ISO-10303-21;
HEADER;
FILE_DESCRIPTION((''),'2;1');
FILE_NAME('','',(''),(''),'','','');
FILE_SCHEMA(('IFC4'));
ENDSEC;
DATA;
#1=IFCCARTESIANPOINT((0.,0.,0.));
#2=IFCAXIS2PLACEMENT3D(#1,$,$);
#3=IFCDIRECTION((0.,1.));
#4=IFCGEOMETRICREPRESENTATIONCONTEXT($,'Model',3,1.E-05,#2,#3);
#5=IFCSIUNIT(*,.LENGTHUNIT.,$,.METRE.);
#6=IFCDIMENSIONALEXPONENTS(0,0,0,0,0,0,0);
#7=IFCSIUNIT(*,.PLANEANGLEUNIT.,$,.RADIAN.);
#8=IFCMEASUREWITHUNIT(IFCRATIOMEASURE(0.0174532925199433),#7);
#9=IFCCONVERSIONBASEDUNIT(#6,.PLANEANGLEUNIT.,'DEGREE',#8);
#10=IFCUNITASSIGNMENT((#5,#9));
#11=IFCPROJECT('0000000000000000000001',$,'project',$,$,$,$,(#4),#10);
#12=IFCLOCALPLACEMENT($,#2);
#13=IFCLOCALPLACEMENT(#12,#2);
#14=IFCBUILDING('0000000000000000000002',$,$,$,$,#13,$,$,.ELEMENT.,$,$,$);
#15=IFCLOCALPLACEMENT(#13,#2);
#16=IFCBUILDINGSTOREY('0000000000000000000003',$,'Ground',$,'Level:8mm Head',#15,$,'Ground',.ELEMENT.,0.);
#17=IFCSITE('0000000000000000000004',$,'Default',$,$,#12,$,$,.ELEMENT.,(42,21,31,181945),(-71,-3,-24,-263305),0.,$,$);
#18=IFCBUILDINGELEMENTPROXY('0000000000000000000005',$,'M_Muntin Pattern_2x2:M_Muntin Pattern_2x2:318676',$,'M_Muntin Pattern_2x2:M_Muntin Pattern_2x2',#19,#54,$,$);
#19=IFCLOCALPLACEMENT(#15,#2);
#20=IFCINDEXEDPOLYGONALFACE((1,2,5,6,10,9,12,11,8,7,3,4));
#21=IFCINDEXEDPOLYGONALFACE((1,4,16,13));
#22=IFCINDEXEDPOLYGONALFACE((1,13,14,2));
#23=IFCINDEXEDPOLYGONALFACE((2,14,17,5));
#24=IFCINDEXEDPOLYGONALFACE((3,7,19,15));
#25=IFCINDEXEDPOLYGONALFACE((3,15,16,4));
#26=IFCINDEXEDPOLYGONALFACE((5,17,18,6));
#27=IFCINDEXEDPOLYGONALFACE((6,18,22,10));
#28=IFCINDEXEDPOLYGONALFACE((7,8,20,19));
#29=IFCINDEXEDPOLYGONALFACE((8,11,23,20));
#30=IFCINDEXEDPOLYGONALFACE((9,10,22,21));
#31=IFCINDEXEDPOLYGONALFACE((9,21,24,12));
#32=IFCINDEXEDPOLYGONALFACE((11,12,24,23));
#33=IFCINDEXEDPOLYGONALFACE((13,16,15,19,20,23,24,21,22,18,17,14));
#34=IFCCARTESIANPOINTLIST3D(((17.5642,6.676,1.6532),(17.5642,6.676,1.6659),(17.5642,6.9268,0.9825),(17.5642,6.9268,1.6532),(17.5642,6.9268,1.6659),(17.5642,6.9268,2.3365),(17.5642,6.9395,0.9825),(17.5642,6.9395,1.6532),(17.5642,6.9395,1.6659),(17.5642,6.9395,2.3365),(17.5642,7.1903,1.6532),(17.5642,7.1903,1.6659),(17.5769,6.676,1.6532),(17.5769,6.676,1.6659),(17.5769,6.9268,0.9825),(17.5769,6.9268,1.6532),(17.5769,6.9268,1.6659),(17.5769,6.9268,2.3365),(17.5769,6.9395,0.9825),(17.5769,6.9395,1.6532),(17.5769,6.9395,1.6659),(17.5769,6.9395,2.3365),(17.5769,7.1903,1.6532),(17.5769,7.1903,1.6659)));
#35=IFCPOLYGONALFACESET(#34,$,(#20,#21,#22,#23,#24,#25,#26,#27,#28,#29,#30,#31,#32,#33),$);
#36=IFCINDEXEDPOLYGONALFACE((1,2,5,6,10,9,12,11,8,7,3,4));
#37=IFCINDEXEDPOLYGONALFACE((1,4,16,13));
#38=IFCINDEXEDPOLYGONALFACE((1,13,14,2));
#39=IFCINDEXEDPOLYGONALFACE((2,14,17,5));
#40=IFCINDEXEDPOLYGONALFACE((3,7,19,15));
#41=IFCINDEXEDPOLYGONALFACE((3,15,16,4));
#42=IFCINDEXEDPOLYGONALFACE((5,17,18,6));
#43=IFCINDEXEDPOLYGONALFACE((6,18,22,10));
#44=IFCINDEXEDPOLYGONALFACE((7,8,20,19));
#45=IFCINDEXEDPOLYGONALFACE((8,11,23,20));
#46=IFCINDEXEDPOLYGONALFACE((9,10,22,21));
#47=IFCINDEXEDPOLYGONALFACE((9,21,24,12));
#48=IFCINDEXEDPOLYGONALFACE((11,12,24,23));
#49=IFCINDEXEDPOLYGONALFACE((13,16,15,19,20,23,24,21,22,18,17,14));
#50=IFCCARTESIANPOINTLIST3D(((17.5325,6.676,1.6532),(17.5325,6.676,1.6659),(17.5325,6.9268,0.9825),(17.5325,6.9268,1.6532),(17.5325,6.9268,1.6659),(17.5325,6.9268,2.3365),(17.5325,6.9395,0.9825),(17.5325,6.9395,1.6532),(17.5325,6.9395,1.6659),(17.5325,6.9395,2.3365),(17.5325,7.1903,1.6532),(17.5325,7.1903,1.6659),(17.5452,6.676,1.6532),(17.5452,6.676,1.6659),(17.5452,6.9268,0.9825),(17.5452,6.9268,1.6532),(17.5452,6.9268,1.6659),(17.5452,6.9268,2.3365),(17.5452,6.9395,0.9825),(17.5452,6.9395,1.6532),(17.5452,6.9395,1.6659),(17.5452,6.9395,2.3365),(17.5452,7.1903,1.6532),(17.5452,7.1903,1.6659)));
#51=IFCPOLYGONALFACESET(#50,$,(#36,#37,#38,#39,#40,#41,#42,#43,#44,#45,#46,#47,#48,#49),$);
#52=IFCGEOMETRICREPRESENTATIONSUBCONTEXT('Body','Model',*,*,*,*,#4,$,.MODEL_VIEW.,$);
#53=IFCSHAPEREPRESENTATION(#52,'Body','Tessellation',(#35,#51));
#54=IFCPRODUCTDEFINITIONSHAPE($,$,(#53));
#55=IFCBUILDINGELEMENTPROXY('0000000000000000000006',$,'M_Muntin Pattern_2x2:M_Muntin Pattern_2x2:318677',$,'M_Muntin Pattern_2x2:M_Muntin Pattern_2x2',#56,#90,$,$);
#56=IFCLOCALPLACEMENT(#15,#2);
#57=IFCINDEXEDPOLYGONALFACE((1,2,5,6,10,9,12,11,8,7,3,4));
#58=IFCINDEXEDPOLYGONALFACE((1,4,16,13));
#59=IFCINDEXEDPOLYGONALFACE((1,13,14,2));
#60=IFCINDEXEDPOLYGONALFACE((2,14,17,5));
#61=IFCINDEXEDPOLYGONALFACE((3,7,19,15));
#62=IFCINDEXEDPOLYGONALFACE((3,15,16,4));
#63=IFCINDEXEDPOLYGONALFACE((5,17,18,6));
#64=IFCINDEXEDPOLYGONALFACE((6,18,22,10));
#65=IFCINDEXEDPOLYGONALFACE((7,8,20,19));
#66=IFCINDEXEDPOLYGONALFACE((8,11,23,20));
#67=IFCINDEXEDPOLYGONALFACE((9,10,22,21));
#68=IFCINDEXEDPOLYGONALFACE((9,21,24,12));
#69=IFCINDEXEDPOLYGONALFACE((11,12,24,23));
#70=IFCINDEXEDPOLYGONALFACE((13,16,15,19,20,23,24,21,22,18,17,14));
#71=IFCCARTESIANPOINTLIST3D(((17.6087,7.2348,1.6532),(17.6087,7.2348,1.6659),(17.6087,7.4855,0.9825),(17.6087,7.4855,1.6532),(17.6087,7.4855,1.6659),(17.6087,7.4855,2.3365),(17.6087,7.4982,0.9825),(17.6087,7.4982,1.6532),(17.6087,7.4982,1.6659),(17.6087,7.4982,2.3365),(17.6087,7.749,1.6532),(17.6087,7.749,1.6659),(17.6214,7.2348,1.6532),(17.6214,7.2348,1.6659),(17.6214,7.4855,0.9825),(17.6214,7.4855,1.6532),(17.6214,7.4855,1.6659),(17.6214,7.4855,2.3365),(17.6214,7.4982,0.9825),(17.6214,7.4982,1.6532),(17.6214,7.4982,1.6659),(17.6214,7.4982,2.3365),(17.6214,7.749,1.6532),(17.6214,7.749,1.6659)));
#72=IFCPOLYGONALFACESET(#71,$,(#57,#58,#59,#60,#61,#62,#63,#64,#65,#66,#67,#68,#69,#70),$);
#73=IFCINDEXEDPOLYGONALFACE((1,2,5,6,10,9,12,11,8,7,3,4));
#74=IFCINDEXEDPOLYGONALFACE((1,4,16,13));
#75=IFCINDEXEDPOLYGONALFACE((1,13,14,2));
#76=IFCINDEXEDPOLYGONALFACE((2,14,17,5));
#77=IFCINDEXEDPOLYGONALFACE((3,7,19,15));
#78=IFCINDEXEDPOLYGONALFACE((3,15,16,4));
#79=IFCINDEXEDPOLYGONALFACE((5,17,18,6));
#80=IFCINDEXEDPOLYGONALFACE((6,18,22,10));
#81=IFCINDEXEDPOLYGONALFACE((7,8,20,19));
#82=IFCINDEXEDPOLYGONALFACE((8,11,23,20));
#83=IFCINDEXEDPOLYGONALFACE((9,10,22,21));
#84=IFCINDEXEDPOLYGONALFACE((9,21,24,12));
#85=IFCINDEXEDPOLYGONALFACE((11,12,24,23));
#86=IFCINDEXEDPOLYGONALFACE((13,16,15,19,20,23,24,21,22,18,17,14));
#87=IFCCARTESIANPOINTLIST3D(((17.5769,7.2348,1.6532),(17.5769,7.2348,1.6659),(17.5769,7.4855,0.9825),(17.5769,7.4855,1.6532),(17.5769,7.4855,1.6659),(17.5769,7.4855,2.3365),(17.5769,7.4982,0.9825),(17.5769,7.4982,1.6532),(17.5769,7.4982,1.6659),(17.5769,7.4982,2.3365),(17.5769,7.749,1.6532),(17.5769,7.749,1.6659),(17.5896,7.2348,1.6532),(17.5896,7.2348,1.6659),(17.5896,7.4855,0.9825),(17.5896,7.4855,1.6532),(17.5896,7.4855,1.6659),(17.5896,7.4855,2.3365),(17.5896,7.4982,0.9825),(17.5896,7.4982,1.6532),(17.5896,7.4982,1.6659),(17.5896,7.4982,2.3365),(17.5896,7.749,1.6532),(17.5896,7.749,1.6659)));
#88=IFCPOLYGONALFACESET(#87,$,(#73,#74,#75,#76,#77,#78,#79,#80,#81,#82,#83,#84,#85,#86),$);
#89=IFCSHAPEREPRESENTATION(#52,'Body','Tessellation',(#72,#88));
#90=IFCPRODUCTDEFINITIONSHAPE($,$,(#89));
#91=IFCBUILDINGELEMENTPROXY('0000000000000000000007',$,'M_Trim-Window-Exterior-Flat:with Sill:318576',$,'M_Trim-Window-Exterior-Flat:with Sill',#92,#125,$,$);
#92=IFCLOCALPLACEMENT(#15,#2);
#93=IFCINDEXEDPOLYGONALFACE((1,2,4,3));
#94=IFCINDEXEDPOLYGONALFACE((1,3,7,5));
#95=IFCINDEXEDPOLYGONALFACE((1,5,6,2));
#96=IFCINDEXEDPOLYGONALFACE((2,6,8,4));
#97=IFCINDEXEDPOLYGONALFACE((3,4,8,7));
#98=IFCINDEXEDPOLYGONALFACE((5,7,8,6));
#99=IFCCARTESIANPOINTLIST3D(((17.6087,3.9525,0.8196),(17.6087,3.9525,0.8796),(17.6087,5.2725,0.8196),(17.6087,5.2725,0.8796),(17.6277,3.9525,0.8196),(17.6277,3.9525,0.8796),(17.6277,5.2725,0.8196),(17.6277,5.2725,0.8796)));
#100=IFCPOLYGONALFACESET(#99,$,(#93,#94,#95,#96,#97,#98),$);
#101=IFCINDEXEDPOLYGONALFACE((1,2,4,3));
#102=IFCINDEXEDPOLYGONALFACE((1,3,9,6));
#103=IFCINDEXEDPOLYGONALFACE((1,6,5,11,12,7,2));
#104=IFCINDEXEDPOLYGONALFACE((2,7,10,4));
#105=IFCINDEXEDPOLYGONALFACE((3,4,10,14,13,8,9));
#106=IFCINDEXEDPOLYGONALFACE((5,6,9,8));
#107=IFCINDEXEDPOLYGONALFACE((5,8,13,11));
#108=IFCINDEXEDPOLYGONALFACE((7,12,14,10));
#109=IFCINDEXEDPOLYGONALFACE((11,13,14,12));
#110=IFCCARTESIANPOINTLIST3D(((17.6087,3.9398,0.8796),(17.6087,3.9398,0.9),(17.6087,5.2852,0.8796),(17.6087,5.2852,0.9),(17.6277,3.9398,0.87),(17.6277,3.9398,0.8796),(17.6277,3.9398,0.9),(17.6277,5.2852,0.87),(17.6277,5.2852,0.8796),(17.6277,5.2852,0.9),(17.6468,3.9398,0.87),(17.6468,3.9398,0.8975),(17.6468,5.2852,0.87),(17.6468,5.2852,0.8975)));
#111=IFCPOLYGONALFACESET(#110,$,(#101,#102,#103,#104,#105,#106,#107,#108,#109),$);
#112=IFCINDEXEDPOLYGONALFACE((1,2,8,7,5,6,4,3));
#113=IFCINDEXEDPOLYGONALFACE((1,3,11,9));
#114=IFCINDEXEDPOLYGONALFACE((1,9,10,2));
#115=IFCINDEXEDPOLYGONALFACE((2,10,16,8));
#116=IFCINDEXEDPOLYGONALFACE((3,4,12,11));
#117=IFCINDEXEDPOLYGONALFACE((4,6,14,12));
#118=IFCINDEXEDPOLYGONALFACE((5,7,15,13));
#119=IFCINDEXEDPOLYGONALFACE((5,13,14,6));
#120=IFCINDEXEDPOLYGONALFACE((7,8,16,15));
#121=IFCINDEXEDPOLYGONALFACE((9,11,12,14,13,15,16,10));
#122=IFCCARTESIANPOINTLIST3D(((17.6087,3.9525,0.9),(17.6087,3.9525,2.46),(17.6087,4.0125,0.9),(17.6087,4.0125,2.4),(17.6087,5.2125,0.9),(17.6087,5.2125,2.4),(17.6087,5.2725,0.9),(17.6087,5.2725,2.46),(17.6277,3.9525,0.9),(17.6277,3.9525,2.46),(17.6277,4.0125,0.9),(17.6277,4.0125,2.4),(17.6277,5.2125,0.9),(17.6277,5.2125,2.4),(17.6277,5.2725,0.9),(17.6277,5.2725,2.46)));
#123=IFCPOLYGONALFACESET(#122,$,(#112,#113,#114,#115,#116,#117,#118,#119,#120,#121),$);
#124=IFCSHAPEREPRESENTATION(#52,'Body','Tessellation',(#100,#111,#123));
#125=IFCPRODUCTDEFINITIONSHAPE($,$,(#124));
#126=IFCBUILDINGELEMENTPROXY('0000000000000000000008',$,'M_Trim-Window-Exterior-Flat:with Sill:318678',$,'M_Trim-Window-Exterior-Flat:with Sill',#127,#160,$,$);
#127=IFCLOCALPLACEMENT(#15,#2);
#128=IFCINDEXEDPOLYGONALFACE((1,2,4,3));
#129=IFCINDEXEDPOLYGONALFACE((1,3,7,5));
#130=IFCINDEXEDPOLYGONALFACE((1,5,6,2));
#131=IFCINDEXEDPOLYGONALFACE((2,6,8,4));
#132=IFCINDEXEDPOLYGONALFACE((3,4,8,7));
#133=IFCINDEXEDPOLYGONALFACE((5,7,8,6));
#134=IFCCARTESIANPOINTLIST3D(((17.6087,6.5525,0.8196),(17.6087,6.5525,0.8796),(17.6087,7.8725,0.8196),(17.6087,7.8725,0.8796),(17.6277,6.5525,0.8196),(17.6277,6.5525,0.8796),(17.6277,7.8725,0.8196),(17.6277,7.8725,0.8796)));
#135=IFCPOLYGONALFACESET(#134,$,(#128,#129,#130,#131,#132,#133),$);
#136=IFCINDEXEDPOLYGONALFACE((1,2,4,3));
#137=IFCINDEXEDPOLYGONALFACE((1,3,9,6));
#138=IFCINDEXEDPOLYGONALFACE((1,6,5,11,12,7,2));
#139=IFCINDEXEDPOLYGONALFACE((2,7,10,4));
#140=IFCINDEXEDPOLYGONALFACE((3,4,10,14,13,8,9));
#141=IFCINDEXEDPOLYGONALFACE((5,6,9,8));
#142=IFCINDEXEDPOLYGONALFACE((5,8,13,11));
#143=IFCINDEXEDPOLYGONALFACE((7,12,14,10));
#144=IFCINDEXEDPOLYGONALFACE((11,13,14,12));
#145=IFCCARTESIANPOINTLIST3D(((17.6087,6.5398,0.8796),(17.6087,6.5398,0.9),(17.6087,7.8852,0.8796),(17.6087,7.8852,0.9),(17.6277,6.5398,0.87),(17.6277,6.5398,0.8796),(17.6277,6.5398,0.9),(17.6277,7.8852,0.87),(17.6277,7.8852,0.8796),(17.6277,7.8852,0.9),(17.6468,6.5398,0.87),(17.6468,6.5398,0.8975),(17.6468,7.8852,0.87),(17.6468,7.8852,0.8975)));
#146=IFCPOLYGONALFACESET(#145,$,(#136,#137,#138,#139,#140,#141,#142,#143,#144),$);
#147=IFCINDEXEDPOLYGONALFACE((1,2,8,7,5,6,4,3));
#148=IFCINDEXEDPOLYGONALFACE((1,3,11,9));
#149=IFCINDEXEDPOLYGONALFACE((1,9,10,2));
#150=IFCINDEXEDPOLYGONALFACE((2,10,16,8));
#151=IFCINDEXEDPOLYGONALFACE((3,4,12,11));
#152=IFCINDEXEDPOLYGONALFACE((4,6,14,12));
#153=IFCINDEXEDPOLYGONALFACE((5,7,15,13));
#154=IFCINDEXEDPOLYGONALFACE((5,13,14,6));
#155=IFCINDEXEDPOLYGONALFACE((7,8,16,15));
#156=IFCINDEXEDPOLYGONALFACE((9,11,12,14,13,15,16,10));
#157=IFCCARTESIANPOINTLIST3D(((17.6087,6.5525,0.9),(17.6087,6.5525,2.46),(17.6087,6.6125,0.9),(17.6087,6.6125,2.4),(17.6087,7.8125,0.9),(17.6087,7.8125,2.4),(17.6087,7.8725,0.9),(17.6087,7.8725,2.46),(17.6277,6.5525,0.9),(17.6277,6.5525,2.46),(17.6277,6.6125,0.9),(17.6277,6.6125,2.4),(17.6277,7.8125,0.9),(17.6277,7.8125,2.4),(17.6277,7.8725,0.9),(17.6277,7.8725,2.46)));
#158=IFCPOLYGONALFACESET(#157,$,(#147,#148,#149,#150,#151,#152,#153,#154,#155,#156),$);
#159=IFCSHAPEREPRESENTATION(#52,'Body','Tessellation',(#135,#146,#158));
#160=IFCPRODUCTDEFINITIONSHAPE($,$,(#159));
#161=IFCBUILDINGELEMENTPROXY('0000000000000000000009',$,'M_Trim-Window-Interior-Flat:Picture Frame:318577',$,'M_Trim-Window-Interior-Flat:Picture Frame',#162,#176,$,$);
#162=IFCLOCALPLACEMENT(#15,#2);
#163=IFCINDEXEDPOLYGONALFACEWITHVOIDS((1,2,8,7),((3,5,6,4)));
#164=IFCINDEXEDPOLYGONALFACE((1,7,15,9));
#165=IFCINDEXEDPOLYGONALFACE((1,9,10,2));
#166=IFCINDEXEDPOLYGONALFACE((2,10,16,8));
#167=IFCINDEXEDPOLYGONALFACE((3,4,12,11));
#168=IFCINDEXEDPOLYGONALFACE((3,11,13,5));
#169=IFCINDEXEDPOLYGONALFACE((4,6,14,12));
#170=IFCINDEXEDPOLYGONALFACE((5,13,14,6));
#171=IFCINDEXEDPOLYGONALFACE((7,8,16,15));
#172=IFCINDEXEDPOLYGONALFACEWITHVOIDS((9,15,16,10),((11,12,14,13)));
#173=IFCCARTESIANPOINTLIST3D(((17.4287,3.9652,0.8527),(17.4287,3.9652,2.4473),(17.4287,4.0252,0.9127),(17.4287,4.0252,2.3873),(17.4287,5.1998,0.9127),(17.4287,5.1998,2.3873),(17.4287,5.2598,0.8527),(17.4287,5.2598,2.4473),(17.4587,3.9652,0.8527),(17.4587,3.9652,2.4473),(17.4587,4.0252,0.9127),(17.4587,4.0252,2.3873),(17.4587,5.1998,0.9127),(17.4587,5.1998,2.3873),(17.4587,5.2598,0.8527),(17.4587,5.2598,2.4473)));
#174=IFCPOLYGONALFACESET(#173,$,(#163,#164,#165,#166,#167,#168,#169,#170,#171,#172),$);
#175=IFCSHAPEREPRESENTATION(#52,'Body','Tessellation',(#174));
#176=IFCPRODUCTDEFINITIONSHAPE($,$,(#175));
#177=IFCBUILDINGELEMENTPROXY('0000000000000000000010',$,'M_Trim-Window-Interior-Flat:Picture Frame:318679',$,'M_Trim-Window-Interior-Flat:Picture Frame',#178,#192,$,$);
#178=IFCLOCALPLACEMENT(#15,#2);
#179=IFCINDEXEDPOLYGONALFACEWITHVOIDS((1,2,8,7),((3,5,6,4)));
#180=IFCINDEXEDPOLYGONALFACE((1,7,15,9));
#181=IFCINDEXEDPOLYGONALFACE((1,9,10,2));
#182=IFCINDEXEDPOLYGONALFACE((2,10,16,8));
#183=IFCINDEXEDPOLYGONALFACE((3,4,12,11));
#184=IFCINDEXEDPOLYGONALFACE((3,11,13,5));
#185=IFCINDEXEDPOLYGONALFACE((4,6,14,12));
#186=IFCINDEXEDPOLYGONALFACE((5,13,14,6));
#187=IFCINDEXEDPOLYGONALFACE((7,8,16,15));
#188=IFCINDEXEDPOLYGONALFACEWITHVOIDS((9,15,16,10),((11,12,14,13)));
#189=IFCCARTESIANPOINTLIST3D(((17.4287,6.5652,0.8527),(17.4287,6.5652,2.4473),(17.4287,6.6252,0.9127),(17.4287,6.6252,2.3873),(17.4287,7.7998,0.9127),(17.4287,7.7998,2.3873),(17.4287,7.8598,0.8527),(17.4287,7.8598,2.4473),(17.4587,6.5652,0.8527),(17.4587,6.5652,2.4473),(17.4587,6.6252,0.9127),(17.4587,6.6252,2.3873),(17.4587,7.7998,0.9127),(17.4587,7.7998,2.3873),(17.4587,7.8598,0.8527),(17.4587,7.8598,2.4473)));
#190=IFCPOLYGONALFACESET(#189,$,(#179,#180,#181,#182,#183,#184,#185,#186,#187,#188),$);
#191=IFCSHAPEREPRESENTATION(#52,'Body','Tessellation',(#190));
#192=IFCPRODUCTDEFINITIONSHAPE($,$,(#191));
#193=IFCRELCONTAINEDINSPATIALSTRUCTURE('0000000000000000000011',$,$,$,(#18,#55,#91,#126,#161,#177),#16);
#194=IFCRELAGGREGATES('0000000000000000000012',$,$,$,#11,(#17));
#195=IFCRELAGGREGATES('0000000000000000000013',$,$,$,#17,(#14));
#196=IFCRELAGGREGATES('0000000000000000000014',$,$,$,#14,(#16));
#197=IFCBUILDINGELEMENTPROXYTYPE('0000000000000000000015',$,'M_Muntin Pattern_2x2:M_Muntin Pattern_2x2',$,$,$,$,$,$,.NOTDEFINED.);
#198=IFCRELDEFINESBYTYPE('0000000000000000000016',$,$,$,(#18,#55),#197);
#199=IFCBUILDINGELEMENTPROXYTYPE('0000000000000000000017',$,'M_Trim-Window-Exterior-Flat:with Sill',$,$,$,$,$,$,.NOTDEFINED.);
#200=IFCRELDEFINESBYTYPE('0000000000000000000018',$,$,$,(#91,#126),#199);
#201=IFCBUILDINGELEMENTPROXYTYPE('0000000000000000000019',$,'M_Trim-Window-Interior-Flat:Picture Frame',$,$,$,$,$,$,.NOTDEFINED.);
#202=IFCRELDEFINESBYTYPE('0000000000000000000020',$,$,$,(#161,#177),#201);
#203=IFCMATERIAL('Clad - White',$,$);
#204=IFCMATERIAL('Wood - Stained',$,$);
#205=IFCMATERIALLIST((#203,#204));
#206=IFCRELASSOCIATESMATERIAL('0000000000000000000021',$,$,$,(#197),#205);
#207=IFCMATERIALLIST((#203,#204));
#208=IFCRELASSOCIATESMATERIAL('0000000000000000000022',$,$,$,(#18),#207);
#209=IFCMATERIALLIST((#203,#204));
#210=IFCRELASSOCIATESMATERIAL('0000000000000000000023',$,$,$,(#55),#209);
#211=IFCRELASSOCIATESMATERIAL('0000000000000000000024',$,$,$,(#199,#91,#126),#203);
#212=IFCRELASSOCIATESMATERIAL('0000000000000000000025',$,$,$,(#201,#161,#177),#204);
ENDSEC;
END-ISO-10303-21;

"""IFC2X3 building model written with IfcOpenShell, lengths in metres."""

from ifc_helpers import new_model, entity, si_unit, converted_unit, direction, frame, frame_2d, origin, place, context, subcontext, project, spatial, polyline, rectangle, outline, extrude, source, transform, mapped, material, material_list, type_object, type_shapes, element, save


model = new_model("IFC2X3")

# Units and contexts
model_context = context("Model", 3, precision=1e-05, world=origin(), true_north=direction((0.0, 1.0)))
body_context = subcontext(model_context, "Body", "Model", "MODEL_VIEW")
ifc_project = project(units=[si_unit("LENGTHUNIT", "METRE"), converted_unit("PLANEANGLEUNIT", "DEGREE", entity("IfcRatioMeasure", 0.0174532925199433), si_unit("PLANEANGLEUNIT", "RADIAN"), dimensions=[0, 0, 0, 0, 0, 0, 0])], contexts=[model_context])

# Site, building, storey
site_placement = place(None, origin())
site = spatial("IfcSite", under=ifc_project, at=site_placement, Name="Default", CompositionType="ELEMENT", RefLatitude=(42, 21, 31, 181945), RefLongitude=(-71, -3, -24, -263305), RefElevation=0.0)
building_placement = place(site_placement, origin())
building = spatial("IfcBuilding", under=site, at=building_placement, CompositionType="ELEMENT")
storey_placement = place(building_placement, origin())
storey = spatial("IfcBuildingStorey", under=building, at=storey_placement, Name="Ground", ObjectType="Level:8mm Head", LongName="Ground", CompositionType="ELEMENT", Elevation=0.0)

# Building element proxies
ifc_material_1 = material(Name="Clad - White")
ifc_material_2 = material(Name="Wood - Stained")
ifc_material_list_1 = material_list([ifc_material_1, ifc_material_2])
building_element_proxy_type_1 = type_object("IfcBuildingElementProxyType", Name="M_Muntin Pattern_2x2:M_Muntin Pattern_2x2", PredefinedType="NOTDEFINED", material=ifc_material_list_1)
shared_shape_1 = source(origin(), body_context, "Body", "SweptSolid", [
    extrude(outline(polyline([(0.0064, -0.0064), (0.677, -0.0064), (0.677, 0.0063), (0.0064, 0.0063), (0.0064, 0.2571), (-0.0063, 0.2571), (-0.0063, 0.0063), (-0.677, 0.0063), (-0.677, -0.0064), (-0.0063, -0.0064), (-0.0063, -0.2571), (0.0064, -0.2571), (0.0064, -0.0064)])), frame((0.0, 0.0095, 0.677), z_axis=(0.0, 1.0, 0.0), x_axis=(0.0, 0.0, 1.0)), (0.0, 0.0, 1.0), 0.0127),
    extrude(outline(polyline([(0.0064, -0.0064), (0.677, -0.0064), (0.677, 0.0063), (0.0064, 0.0063), (0.0064, 0.2571), (-0.0063, 0.2571), (-0.0063, 0.0063), (-0.677, 0.0063), (-0.677, -0.0064), (-0.0063, -0.0064), (-0.0063, -0.2571), (0.0064, -0.2571), (0.0064, -0.0064)])), frame((0.0, -0.0222, 0.677), z_axis=(0.0, 1.0, 0.0), x_axis=(0.0, 0.0, 1.0)), (0.0, 0.0, 1.0), 0.0127),
])
type_shapes(building_element_proxy_type_1, [shared_shape_1])
ifc_material_list_2 = material_list([ifc_material_1, ifc_material_2])
proxy_1_placement = place(storey_placement, frame((17.5547, 6.9332, 0.9825), z_axis=(0.0, 0.0, 1.0), x_axis=(0.0, -1.0, 0.0)))
element("IfcBuildingElementProxy", 1, at=proxy_1_placement, inside=storey, type_object=building_element_proxy_type_1, material=ifc_material_list_2, Name="M_Muntin Pattern_2x2:M_Muntin Pattern_2x2:318676", ObjectType="M_Muntin Pattern_2x2:M_Muntin Pattern_2x2", context=body_context, shape_type="MappedRepresentation", body=[
    mapped(shared_shape_1, transform((0.0, 0.0, 0.0), scale=1.0)),
])
ifc_material_list_3 = material_list([ifc_material_1, ifc_material_2])
proxy_2_placement = place(storey_placement, frame((17.5991, 7.4919, 0.9825), z_axis=(0.0, 0.0, 1.0), x_axis=(0.0, -1.0, 0.0)))
element("IfcBuildingElementProxy", 2, at=proxy_2_placement, inside=storey, type_object=building_element_proxy_type_1, material=ifc_material_list_3, Name="M_Muntin Pattern_2x2:M_Muntin Pattern_2x2:318677", ObjectType="M_Muntin Pattern_2x2:M_Muntin Pattern_2x2", context=body_context, shape_type="MappedRepresentation", body=[
    mapped(shared_shape_1, transform((0.0, 0.0, 0.0), scale=1.0)),
])
building_element_proxy_type_2 = type_object("IfcBuildingElementProxyType", Name="M_Trim-Window-Exterior-Flat:with Sill", PredefinedType="NOTDEFINED", material=ifc_material_1)
shared_shape_2 = source(origin(), body_context, "Body", "SweptSolid", [
    extrude(rectangle(XDim=1.32, YDim=0.06, at=frame_2d((0.0, 0.0), x_axis=(1.0, 0.0))), frame((0.0, -1.5504, 0.0), z_axis=(0.0, 0.0, 1.0), x_axis=(-1.0, 0.0, 0.0)), (0.0, 0.0, 1.0), 0.0191),
    extrude(outline(polyline([(-0.019, -0.0152), (0.0, -0.0152), (0.0, -0.0057), (0.019, -0.0057), (0.019, 0.0148), (0.0, 0.0148), (-0.019, 0.0123), (-0.019, -0.0152)])), frame((-0.6727, -1.5148, 0.019), z_axis=(1.0, 0.0, 0.0), x_axis=(0.0, 0.0, -1.0)), (0.0, 0.0, 1.0), 1.3454),
    extrude(outline(polyline([(-0.795, -0.66), (0.765, -0.66), (0.765, -0.6), (-0.735, -0.6), (-0.735, 0.6), (0.765, 0.6), (0.765, 0.66), (-0.795, 0.66), (-0.795, -0.66)])), frame((0.0, -0.735, 0.0), z_axis=(0.0, 0.0, 1.0), x_axis=(0.0, -1.0, 0.0)), (0.0, 0.0, 1.0), 0.0191),
])
type_shapes(building_element_proxy_type_2, [shared_shape_2])
for number, where, z_axis, x_axis, name in (
    (3, (17.6087, 4.6125, 2.4), (1.0, 0.0, 0.0), (0.0, 1.0, 0.0), "M_Trim-Window-Exterior-Flat:with Sill:318576"),
    (4, (17.6087, 7.2125, 2.4), (1.0, 0.0, 0.0), (0.0, 1.0, 0.0), "M_Trim-Window-Exterior-Flat:with Sill:318678"),
):
    element("IfcBuildingElementProxy", number, at=place(storey_placement, frame(where, z_axis=z_axis, x_axis=x_axis)), inside=storey, type_object=building_element_proxy_type_2, material=ifc_material_1, Name=name, ObjectType="M_Trim-Window-Exterior-Flat:with Sill", context=body_context, shape_type="MappedRepresentation", body=[
        mapped(shared_shape_2, transform((0.0, 0.0, 0.0), scale=1.0)),
    ])
building_element_proxy_type_3 = type_object("IfcBuildingElementProxyType", Name="M_Trim-Window-Interior-Flat:Picture Frame", PredefinedType="NOTDEFINED", material=ifc_material_2)
shared_shape_3 = source(origin(), body_context, "Body", "SweptSolid", [
    extrude(outline(polyline([(-0.6473, -0.7973), (0.6473, -0.7973), (0.6473, 0.7973), (-0.6473, 0.7973), (-0.6473, -0.7973)]), holes=[polyline([(-0.5873, -0.7373), (-0.5873, 0.7373), (0.5873, 0.7373), (0.5873, -0.7373), (-0.5873, -0.7373)])]), frame((0.0, -0.75, 0.0), z_axis=(0.0, 0.0, 1.0), x_axis=(-1.0, 0.0, 0.0)), (0.0, 0.0, 1.0), 0.03),
])
type_shapes(building_element_proxy_type_3, [shared_shape_3])
for number, where, z_axis, x_axis, name in (
    (5, (17.4587, 4.6125, 2.4), (-1.0, 0.0, 0.0), (0.0, -1.0, 0.0), "M_Trim-Window-Interior-Flat:Picture Frame:318577"),
    (6, (17.4587, 7.2125, 2.4), (-1.0, 0.0, 0.0), (0.0, -1.0, 0.0), "M_Trim-Window-Interior-Flat:Picture Frame:318679"),
):
    element("IfcBuildingElementProxy", number, at=place(storey_placement, frame(where, z_axis=z_axis, x_axis=x_axis)), inside=storey, type_object=building_element_proxy_type_3, material=ifc_material_2, Name=name, ObjectType="M_Trim-Window-Interior-Flat:Picture Frame", context=body_context, shape_type="MappedRepresentation", body=[
        mapped(shared_shape_3, transform((0.0, 0.0, 0.0), scale=1.0)),
    ])

save(model, "model.ifc")
